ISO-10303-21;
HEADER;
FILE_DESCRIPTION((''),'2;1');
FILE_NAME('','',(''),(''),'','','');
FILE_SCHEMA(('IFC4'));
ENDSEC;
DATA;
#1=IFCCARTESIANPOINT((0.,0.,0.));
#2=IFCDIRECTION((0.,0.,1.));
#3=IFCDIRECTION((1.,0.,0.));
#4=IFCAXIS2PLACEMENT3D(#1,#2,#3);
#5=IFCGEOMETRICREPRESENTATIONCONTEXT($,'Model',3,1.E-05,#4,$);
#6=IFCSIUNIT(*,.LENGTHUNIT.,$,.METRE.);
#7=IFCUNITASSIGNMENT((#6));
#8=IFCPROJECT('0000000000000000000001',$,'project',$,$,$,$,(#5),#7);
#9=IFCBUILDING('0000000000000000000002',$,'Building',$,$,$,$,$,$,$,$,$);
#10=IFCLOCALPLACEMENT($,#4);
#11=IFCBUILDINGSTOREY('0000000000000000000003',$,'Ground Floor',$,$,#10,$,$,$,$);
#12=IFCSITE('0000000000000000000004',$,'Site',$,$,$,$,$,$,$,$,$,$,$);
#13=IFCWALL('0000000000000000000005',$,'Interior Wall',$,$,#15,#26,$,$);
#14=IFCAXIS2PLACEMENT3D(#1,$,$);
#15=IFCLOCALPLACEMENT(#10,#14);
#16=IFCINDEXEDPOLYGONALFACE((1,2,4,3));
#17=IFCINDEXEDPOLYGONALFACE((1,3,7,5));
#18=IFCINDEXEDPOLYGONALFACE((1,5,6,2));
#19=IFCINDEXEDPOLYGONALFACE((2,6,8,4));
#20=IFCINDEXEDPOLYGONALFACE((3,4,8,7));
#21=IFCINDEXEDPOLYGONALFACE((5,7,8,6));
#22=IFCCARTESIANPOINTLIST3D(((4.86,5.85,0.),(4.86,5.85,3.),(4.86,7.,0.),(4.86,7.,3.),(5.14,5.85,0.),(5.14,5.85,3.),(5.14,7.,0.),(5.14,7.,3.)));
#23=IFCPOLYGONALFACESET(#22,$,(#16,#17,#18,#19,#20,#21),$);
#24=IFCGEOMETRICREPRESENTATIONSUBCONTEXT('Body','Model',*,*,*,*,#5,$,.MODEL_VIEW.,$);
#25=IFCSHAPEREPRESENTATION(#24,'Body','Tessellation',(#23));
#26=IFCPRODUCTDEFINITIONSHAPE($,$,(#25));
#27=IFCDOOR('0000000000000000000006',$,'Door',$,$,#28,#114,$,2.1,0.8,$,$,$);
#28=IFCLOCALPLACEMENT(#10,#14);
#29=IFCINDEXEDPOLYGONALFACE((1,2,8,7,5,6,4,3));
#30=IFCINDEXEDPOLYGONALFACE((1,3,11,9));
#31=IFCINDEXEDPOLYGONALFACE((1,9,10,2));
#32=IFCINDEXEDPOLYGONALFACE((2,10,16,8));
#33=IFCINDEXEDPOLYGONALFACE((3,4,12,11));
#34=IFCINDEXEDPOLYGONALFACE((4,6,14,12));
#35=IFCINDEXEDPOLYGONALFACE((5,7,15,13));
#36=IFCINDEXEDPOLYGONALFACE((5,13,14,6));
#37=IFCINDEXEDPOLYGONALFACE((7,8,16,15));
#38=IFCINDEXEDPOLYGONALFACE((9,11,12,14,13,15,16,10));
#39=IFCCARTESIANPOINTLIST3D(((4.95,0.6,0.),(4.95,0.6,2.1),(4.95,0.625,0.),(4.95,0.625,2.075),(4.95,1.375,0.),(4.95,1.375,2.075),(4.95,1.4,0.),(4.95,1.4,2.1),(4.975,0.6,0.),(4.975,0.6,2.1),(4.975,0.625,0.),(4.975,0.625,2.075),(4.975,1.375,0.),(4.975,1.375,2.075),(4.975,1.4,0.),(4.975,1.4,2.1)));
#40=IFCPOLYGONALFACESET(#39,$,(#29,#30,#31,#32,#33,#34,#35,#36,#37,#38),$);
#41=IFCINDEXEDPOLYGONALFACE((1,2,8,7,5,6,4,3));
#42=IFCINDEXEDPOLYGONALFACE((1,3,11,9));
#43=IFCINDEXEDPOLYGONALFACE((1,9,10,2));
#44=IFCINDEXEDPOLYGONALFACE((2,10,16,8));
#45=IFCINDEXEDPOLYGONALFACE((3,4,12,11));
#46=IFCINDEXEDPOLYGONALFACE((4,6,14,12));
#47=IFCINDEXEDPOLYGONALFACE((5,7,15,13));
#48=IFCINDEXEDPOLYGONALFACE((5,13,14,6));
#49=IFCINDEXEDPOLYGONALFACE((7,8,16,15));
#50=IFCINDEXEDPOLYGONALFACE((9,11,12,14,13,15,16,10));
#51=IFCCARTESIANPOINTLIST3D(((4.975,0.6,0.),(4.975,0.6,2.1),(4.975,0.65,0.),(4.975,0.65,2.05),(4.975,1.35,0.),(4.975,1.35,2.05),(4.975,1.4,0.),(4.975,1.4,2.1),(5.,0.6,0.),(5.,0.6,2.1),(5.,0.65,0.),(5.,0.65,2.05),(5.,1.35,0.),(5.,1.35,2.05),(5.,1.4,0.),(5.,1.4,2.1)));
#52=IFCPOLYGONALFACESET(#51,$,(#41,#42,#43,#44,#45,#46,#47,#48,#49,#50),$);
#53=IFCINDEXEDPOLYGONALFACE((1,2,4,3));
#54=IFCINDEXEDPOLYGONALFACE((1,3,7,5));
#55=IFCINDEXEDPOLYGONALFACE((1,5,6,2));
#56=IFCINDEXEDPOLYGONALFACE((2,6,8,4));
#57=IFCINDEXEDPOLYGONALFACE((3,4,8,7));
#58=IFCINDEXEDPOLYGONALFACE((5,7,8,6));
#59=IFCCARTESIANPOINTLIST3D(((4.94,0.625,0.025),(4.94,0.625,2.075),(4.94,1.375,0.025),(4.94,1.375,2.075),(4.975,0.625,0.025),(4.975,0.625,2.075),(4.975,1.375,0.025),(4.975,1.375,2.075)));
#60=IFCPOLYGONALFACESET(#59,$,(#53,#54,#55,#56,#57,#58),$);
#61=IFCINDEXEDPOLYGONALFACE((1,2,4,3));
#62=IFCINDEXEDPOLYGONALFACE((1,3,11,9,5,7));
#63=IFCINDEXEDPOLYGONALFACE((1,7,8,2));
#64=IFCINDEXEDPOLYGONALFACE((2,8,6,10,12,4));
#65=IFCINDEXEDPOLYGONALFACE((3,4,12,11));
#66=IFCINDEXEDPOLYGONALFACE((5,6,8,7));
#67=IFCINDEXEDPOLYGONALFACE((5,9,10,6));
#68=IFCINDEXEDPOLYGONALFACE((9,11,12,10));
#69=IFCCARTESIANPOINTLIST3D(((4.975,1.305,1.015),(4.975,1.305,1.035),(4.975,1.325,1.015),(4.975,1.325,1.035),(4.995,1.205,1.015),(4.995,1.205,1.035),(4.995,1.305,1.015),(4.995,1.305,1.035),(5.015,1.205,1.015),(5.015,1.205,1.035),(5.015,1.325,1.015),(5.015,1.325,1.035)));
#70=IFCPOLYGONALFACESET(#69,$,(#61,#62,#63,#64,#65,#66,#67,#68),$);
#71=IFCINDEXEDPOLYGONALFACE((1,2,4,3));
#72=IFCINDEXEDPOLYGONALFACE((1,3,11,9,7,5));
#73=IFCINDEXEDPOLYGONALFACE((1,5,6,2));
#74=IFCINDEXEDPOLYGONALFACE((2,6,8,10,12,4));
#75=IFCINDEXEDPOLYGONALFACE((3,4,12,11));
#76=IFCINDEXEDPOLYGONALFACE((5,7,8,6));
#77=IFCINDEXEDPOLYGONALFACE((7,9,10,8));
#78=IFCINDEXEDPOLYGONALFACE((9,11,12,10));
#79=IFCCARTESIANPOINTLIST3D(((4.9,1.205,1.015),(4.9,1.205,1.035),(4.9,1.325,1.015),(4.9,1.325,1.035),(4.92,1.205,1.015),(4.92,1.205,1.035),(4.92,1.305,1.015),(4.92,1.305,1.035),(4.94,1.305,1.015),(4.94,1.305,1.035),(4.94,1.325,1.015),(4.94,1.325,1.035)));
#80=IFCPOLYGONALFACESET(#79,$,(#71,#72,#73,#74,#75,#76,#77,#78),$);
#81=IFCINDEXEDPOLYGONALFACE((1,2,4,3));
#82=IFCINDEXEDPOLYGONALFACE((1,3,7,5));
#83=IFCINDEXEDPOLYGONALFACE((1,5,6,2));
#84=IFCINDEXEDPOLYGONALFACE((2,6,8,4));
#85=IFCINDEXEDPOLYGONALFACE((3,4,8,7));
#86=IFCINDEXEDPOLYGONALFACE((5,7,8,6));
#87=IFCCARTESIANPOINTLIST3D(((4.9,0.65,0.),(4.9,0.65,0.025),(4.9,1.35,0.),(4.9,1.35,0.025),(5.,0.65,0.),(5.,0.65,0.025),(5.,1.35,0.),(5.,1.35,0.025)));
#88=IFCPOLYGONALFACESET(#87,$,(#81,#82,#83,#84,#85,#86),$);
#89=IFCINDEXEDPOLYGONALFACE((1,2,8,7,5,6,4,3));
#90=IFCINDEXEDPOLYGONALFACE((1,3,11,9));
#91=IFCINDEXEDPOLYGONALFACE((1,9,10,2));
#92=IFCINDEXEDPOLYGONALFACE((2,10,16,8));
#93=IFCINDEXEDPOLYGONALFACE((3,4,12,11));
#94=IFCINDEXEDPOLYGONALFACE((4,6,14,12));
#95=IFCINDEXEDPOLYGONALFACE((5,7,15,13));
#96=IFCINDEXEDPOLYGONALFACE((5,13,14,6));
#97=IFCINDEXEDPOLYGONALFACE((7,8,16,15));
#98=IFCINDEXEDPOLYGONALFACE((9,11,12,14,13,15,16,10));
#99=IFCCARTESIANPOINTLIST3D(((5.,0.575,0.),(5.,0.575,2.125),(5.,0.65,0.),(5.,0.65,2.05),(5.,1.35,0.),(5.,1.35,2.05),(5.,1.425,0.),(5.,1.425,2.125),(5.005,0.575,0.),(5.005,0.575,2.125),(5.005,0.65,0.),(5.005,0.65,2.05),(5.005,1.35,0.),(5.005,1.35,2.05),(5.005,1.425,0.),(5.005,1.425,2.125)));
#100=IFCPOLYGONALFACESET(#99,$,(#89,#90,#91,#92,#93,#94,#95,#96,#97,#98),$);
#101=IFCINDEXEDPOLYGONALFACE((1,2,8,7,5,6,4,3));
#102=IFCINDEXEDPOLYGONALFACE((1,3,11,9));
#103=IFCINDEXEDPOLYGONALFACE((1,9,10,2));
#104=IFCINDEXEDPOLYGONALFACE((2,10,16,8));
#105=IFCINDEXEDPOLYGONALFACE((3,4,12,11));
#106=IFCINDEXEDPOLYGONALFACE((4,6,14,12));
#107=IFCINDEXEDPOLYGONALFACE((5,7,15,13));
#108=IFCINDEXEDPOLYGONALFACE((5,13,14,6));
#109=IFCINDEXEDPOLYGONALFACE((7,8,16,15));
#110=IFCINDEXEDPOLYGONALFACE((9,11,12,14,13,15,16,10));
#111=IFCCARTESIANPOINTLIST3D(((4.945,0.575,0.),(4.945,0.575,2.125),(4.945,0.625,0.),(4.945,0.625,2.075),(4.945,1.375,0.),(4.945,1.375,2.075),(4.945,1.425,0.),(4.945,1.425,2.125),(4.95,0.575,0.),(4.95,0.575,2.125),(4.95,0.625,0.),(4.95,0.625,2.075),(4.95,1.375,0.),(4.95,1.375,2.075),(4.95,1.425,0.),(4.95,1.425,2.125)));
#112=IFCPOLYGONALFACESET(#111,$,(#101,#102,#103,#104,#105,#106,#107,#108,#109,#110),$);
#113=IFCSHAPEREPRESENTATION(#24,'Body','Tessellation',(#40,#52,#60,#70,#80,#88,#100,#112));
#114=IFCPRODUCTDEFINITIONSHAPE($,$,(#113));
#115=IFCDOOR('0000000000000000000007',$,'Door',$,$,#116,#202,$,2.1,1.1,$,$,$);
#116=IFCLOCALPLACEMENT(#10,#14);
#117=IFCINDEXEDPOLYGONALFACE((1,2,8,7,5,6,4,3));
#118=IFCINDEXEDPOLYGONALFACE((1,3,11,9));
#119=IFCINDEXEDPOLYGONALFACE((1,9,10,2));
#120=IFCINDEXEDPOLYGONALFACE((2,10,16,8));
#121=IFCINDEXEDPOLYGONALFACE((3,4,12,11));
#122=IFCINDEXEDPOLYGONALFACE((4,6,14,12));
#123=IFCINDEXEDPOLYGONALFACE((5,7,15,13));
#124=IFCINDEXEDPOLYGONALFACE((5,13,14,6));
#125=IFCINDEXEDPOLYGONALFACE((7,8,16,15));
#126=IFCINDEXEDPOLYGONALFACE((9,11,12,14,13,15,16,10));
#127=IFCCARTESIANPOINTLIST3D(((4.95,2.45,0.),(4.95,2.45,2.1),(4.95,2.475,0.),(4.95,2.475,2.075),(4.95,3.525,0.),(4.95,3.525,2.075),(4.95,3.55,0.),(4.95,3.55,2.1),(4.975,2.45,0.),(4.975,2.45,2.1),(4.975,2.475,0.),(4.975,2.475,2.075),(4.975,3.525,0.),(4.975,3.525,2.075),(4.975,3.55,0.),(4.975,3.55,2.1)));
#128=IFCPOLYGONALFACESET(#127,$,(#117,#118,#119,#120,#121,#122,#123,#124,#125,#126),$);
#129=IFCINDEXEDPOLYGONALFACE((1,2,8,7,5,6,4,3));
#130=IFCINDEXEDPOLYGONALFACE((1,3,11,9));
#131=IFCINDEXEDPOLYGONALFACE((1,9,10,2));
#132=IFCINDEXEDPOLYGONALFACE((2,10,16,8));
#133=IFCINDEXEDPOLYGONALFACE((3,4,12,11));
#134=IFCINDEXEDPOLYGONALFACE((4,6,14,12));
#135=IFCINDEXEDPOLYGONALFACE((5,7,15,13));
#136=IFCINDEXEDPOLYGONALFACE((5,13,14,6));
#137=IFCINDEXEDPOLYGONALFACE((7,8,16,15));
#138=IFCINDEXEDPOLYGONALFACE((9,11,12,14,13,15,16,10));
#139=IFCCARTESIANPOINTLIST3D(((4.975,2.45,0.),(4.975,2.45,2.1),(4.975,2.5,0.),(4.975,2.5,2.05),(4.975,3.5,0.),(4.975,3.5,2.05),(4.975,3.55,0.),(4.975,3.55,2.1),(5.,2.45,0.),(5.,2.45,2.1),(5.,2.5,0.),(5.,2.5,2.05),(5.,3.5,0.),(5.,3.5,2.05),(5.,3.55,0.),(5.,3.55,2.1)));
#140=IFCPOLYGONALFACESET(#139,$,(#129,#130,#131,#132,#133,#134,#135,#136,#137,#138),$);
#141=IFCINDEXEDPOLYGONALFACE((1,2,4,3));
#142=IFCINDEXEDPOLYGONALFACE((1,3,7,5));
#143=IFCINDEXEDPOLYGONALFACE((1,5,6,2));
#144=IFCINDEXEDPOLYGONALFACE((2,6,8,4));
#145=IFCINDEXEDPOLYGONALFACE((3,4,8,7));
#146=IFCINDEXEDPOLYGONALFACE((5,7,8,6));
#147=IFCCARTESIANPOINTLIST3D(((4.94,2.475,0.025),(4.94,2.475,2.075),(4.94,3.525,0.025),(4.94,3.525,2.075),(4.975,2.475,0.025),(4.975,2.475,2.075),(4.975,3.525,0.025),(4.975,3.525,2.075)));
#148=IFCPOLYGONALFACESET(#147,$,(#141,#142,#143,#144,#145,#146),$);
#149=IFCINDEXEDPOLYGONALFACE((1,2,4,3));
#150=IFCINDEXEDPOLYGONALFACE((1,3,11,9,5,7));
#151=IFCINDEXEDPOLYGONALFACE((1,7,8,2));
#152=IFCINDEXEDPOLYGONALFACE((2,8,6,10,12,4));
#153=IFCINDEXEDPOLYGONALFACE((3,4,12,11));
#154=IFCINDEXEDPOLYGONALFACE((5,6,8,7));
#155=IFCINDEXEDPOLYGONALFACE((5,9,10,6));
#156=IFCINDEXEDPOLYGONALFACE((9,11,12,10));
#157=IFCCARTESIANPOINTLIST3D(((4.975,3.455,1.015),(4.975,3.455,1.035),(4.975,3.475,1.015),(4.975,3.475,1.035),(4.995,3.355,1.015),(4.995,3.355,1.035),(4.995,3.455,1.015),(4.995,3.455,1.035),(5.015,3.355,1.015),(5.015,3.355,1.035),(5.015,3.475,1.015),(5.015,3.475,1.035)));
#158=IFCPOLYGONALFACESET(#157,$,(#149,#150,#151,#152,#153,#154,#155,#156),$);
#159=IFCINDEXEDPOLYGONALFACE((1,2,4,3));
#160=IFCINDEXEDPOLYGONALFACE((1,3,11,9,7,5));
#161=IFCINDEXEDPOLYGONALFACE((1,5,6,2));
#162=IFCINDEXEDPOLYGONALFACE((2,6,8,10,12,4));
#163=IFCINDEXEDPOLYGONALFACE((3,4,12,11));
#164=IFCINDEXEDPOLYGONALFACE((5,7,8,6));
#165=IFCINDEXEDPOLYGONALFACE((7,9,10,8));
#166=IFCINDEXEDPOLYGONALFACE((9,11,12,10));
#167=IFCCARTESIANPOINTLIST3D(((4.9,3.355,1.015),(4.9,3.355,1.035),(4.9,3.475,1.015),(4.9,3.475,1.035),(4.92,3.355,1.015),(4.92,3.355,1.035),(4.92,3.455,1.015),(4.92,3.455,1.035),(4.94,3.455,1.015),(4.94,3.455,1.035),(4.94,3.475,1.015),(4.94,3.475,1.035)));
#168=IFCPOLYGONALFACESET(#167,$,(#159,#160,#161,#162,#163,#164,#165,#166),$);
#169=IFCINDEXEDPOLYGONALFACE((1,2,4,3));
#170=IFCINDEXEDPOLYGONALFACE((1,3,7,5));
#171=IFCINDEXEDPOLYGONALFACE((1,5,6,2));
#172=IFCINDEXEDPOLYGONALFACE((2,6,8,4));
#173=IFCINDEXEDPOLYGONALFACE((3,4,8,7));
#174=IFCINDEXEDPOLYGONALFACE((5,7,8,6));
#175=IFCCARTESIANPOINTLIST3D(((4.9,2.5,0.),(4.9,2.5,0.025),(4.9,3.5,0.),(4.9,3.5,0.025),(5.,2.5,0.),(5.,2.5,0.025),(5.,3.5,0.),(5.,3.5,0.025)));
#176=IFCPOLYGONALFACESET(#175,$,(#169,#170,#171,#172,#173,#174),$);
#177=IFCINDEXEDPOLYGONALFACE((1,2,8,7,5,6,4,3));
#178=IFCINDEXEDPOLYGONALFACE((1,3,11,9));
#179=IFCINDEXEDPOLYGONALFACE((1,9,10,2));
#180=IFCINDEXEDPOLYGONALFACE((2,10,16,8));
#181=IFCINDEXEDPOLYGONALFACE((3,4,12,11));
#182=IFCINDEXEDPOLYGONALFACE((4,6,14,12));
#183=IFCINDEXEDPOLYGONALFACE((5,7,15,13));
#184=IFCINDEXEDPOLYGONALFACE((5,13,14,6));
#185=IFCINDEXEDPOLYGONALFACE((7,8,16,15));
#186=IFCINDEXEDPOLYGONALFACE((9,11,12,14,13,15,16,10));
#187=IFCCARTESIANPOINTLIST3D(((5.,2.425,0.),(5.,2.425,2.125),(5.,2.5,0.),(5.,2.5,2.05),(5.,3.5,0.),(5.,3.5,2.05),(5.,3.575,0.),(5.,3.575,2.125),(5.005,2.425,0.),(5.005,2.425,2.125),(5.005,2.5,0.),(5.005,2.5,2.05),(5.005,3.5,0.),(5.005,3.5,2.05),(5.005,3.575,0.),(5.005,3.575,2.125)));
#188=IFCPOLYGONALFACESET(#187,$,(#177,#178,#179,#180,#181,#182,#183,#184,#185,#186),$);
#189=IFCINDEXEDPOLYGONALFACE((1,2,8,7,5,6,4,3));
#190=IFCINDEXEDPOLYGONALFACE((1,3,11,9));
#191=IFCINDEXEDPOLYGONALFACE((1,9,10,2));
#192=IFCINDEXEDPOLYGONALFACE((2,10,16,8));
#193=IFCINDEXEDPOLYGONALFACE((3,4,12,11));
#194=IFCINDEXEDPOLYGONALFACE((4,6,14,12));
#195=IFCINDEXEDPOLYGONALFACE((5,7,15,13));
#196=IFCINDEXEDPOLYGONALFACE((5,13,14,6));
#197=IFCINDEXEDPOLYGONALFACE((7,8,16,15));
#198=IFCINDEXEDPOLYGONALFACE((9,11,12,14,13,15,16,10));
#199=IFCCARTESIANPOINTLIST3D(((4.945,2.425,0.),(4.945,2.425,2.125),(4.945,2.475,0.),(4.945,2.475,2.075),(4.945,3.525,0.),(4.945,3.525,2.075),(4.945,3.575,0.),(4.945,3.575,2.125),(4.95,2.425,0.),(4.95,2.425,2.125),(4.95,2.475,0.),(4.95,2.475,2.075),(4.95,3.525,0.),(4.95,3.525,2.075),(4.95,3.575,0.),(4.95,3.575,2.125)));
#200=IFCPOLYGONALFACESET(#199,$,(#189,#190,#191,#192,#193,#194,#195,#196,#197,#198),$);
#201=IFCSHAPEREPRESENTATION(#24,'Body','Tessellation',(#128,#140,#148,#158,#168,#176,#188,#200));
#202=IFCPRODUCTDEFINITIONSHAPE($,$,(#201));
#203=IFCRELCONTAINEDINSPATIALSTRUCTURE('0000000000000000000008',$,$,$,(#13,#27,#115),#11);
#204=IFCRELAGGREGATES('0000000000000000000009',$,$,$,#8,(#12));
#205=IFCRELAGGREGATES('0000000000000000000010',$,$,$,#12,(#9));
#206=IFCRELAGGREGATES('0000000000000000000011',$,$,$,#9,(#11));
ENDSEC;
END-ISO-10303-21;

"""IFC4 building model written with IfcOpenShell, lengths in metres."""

from ifc_helpers import new_model, si_unit, frame, origin_with_axes, place, context, subcontext, project, spatial, line, indexed_curve, outline, extrude, element, save


model = new_model("IFC4")

# Units and contexts
model_context = context("Model", 3, precision=1e-05, world=origin_with_axes())
body_context = subcontext(model_context, "Body", "Model", "MODEL_VIEW")
ifc_project = project(units=[si_unit("LENGTHUNIT", "METRE")], contexts=[model_context])

# Site, building, storey
site = spatial("IfcSite", under=ifc_project, Name="Site")
building = spatial("IfcBuilding", under=site, Name="Building")
storey_placement = place(None, origin_with_axes())
storey = spatial("IfcBuildingStorey", under=building, at=storey_placement, Name="Ground Floor")

# Wall
for number, where, z_axis, x_axis, name in (
    (1, (5.0, 5.85, 0.0), (0.0, 0.0, 1.0), (0.0, 1.0, 0.0), "Interior Wall"),
):
    element("IfcWall", number, at=place(storey_placement, frame(where, z_axis=z_axis, x_axis=x_axis)), inside=storey, Name=name, context=body_context, shape_type="SweptSolid", body=[
        extrude(outline(indexed_curve([(0.0, 0.0), (0.0, 0.28), (1.15, 0.28), (1.15, 0.0), (0.0, 0.0)], self_intersect=False)), frame((0.0, -0.14, 0.0), z_axis=(0.0, 0.0, 1.0), x_axis=(1.0, 0.0, 0.0)), (0.0, 0.0, 1.0), 3.0),
    ])

# Doors
door_1_placement = place(storey_placement, frame((5.0, 0.6, 0.0), z_axis=(0.0, 0.0, 1.0), x_axis=(0.0, 1.0, 0.0)))
element("IfcDoor", 2, at=door_1_placement, inside=storey, Name="Door", OverallHeight=2.1, OverallWidth=0.8, context=body_context, shape_type="SweptSolid", body=[
    extrude(outline(indexed_curve([(0.0, 0.0), (0.0, 2.1), (0.8, 2.1), (0.8, 0.0), (0.775, 0.0), (0.775, 2.075), (0.025, 2.075), (0.025, 0.0)], segments=[line(1, 2, 3, 4, 5, 6, 7, 8, 1)])), frame((0.0, 0.025, 0.0), z_axis=(0.0, -1.0, 0.0), x_axis=(1.0, 0.0, 0.0)), (0.0, 0.0, -1.0), 0.025),
    extrude(outline(indexed_curve([(0.0, 0.0), (0.0, 2.1), (0.8, 2.1), (0.8, 0.0), (0.75, 0.0), (0.75, 2.05), (0.05, 2.05), (0.05, 0.0)], segments=[line(1, 2, 3, 4, 5, 6, 7, 8, 1)])), frame((0.0, 0.0, 0.0), z_axis=(0.0, -1.0, 0.0), x_axis=(1.0, 0.0, 0.0)), (0.0, 0.0, -1.0), 0.025),
    extrude(outline(indexed_curve([(0.0, 0.0), (0.75, 0.0), (0.75, 0.035), (0.0, 0.035)], segments=[line(1, 2, 3, 4, 1)])), frame((0.025, 0.025, 0.025), z_axis=(0.0, 0.0, 1.0), x_axis=(1.0, 0.0, 0.0)), (0.0, 0.0, 1.0), 2.05),
    extrude(outline(indexed_curve([(0.0, 0.0), (0.0, -0.04), (-0.12, -0.04), (-0.12, -0.02), (-0.02, -0.02), (-0.02, 0.0)], segments=[line(1, 2, 3, 4, 5, 6, 1)])), frame((0.725, 0.025, 1.015), z_axis=(0.0, 0.0, 1.0), x_axis=(1.0, 0.0, 0.0)), (0.0, 0.0, 1.0), 0.02),
    extrude(outline(indexed_curve([(0.0, 0.0), (0.0, 0.04), (-0.12, 0.04), (-0.12, 0.02), (-0.02, 0.02), (-0.02, 0.0)], segments=[line(1, 2, 3, 4, 5, 6, 1)])), frame((0.725, 0.06, 1.015), z_axis=(0.0, 0.0, 1.0), x_axis=(1.0, 0.0, 0.0)), (0.0, 0.0, 1.0), 0.02),
    extrude(outline(indexed_curve([(0.0, 0.0), (0.7, 0.0), (0.7, 0.1), (0.0, 0.1)], segments=[line(1, 2, 3, 4, 1)])), frame((0.05, 0.0, 0.0), z_axis=(0.0, 0.0, 1.0), x_axis=(1.0, 0.0, 0.0)), (0.0, 0.0, 1.0), 0.025),
    extrude(outline(indexed_curve([(0.0, 0.0), (0.0, 2.125), (0.85, 2.125), (0.85, 0.0), (0.775, 0.0), (0.775, 2.05), (0.075, 2.05), (0.075, 0.0)], segments=[line(1, 2, 3, 4, 5, 6, 7, 8, 1)])), frame((-0.025, -0.005, 0.0), z_axis=(0.0, -1.0, 0.0), x_axis=(1.0, 0.0, 0.0)), (0.0, 0.0, -1.0), 0.005),
    extrude(outline(indexed_curve([(0.0, 0.0), (0.0, 2.125), (0.85, 2.125), (0.85, 0.0), (0.8, 0.0), (0.8, 2.075), (0.05, 2.075), (0.05, 0.0)], segments=[line(1, 2, 3, 4, 5, 6, 7, 8, 1)])), frame((-0.025, 0.05, 0.0), z_axis=(0.0, -1.0, 0.0), x_axis=(1.0, 0.0, 0.0)), (0.0, 0.0, -1.0), 0.005),
])
door_2_placement = place(storey_placement, frame((5.0, 2.45, 0.0), z_axis=(0.0, 0.0, 1.0), x_axis=(0.0, 1.0, 0.0)))
element("IfcDoor", 3, at=door_2_placement, inside=storey, Name="Door", OverallHeight=2.1, OverallWidth=1.1, context=body_context, shape_type="SweptSolid", body=[
    extrude(outline(indexed_curve([(0.0, 0.0), (0.0, 2.1), (1.1, 2.1), (1.1, 0.0), (1.075, 0.0), (1.075, 2.075), (0.025, 2.075), (0.025, 0.0)], segments=[line(1, 2, 3, 4, 5, 6, 7, 8, 1)])), frame((0.0, 0.025, 0.0), z_axis=(0.0, -1.0, 0.0), x_axis=(1.0, 0.0, 0.0)), (0.0, 0.0, -1.0), 0.025),
    extrude(outline(indexed_curve([(0.0, 0.0), (0.0, 2.1), (1.1, 2.1), (1.1, 0.0), (1.05, 0.0), (1.05, 2.05), (0.05, 2.05), (0.05, 0.0)], segments=[line(1, 2, 3, 4, 5, 6, 7, 8, 1)])), frame((0.0, 0.0, 0.0), z_axis=(0.0, -1.0, 0.0), x_axis=(1.0, 0.0, 0.0)), (0.0, 0.0, -1.0), 0.025),
    extrude(outline(indexed_curve([(0.0, 0.0), (1.05, 0.0), (1.05, 0.035), (0.0, 0.035)], segments=[line(1, 2, 3, 4, 1)])), frame((0.025, 0.025, 0.025), z_axis=(0.0, 0.0, 1.0), x_axis=(1.0, 0.0, 0.0)), (0.0, 0.0, 1.0), 2.05),
    extrude(outline(indexed_curve([(0.0, 0.0), (0.0, -0.04), (-0.12, -0.04), (-0.12, -0.02), (-0.02, -0.02), (-0.02, 0.0)], segments=[line(1, 2, 3, 4, 5, 6, 1)])), frame((1.025, 0.025, 1.015), z_axis=(0.0, 0.0, 1.0), x_axis=(1.0, 0.0, 0.0)), (0.0, 0.0, 1.0), 0.02),
    extrude(outline(indexed_curve([(0.0, 0.0), (0.0, 0.04), (-0.12, 0.04), (-0.12, 0.02), (-0.02, 0.02), (-0.02, 0.0)], segments=[line(1, 2, 3, 4, 5, 6, 1)])), frame((1.025, 0.06, 1.015), z_axis=(0.0, 0.0, 1.0), x_axis=(1.0, 0.0, 0.0)), (0.0, 0.0, 1.0), 0.02),
    extrude(outline(indexed_curve([(0.0, 0.0), (1.0, 0.0), (1.0, 0.1), (0.0, 0.1)], segments=[line(1, 2, 3, 4, 1)])), frame((0.05, 0.0, 0.0), z_axis=(0.0, 0.0, 1.0), x_axis=(1.0, 0.0, 0.0)), (0.0, 0.0, 1.0), 0.025),
    extrude(outline(indexed_curve([(0.0, 0.0), (0.0, 2.125), (1.15, 2.125), (1.15, 0.0), (1.075, 0.0), (1.075, 2.05), (0.075, 2.05), (0.075, 0.0)], segments=[line(1, 2, 3, 4, 5, 6, 7, 8, 1)])), frame((-0.025, -0.005, 0.0), z_axis=(0.0, -1.0, 0.0), x_axis=(1.0, 0.0, 0.0)), (0.0, 0.0, -1.0), 0.005),
    extrude(outline(indexed_curve([(0.0, 0.0), (0.0, 2.125), (1.15, 2.125), (1.15, 0.0), (1.1, 0.0), (1.1, 2.075), (0.05, 2.075), (0.05, 0.0)], segments=[line(1, 2, 3, 4, 5, 6, 7, 8, 1)])), frame((-0.025, 0.05, 0.0), z_axis=(0.0, -1.0, 0.0), x_axis=(1.0, 0.0, 0.0)), (0.0, 0.0, -1.0), 0.005),
])

save(model, "model.ifc")
